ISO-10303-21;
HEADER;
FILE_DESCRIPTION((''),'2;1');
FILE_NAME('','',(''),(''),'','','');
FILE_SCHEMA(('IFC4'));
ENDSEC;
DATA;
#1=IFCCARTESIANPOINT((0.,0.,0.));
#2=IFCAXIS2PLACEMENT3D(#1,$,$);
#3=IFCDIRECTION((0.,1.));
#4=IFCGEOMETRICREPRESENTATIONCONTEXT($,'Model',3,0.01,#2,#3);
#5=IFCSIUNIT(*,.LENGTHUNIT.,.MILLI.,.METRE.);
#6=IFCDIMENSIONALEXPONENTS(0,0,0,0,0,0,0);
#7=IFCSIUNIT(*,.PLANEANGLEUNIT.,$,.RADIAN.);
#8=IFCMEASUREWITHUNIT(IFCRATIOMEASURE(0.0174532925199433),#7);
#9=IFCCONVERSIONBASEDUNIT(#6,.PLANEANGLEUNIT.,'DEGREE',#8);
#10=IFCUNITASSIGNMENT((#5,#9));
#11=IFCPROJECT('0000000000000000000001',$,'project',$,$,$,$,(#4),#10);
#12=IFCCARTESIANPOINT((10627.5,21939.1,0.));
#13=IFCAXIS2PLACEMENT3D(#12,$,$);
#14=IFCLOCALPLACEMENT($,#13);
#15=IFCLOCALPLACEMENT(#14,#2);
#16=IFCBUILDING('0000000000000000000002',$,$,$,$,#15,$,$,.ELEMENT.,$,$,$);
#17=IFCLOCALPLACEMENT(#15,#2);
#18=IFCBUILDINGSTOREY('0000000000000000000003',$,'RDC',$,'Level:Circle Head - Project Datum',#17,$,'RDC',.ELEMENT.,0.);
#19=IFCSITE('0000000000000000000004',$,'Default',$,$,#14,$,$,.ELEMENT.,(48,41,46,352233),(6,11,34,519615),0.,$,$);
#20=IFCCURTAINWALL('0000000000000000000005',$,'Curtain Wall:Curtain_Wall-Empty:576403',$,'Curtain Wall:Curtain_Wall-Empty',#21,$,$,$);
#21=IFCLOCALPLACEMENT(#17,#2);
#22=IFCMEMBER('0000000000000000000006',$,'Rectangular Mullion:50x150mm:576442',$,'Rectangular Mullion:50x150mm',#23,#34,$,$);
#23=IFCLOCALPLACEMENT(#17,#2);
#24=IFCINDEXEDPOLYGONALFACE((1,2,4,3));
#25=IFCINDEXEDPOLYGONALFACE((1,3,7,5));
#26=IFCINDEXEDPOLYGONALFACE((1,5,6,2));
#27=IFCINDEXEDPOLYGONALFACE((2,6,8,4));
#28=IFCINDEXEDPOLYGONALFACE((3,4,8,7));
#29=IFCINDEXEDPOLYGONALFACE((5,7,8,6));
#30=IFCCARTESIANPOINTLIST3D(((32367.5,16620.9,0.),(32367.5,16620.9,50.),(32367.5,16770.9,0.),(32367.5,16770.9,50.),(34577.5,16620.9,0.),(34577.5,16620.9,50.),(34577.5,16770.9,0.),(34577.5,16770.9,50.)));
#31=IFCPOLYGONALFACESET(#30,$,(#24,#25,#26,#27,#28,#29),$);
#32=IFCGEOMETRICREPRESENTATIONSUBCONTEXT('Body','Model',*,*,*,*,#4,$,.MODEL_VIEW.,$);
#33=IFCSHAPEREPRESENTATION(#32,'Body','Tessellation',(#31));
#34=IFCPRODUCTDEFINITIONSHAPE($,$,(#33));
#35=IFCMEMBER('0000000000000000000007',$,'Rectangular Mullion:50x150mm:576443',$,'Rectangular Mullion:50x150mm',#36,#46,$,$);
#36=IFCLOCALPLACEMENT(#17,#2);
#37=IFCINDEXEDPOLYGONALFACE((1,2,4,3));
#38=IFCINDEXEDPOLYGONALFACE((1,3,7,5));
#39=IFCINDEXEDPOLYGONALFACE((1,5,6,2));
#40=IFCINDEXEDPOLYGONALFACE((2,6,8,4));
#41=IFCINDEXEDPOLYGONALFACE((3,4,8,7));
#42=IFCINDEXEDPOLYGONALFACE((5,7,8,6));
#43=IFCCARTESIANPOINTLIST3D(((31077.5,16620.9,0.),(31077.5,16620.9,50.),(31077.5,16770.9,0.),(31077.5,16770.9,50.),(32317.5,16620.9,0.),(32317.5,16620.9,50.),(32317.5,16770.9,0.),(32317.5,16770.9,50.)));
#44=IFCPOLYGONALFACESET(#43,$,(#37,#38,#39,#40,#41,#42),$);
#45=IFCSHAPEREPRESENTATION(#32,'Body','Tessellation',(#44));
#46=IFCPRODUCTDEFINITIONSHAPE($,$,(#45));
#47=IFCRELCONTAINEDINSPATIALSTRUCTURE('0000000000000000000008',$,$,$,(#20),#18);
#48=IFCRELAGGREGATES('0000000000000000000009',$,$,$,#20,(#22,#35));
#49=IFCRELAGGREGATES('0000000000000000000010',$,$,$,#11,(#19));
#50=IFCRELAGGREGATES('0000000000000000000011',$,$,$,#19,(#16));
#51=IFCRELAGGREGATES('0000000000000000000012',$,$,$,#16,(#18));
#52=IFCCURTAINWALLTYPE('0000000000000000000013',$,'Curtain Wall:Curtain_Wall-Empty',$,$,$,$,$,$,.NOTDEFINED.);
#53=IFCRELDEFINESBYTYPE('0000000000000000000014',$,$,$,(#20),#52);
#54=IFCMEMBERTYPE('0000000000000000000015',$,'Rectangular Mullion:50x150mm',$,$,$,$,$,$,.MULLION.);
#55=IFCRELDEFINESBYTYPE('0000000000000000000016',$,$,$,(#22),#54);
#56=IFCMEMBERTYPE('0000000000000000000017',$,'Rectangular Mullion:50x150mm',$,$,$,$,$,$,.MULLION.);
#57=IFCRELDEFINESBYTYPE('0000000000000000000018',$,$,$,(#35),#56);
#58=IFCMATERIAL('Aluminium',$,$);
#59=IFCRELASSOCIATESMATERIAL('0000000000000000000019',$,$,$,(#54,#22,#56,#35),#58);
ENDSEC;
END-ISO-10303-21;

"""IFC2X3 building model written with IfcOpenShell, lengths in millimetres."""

from ifc_helpers import new_model, entity, si_unit, converted_unit, direction, frame, origin, origin_2d_with_axis, place, context, subcontext, project, spatial, rectangle, extrude, source, transform, mapped, material, type_object, type_shapes, element, aggregate, save


model = new_model("IFC2X3")

# Units and contexts
model_context = context("Model", 3, precision=0.01, world=origin(), true_north=direction((0.0, 1.0)))
body_context = subcontext(model_context, "Body", "Model", "MODEL_VIEW")
ifc_project = project(units=[si_unit("LENGTHUNIT", "METRE", prefix="MILLI"), converted_unit("PLANEANGLEUNIT", "DEGREE", entity("IfcRatioMeasure", 0.0174532925199433), si_unit("PLANEANGLEUNIT", "RADIAN"), dimensions=[0, 0, 0, 0, 0, 0, 0])], contexts=[model_context])

# Site, building, storey
site_placement = place(None, frame((10627.5, 21939.1, 0.0)))
site = spatial("IfcSite", under=ifc_project, at=site_placement, Name="Default", CompositionType="ELEMENT", RefLatitude=(48, 41, 46, 352233), RefLongitude=(6, 11, 34, 519615), RefElevation=0.0)
building_placement = place(site_placement, origin())
building = spatial("IfcBuilding", under=site, at=building_placement, CompositionType="ELEMENT")
storey_placement = place(building_placement, origin())
storey = spatial("IfcBuildingStorey", under=building, at=storey_placement, Name="RDC", ObjectType="Level:Circle Head - Project Datum", LongName="RDC", CompositionType="ELEMENT", Elevation=0.0)

# Curtain wall, members
curtain_wall_type = type_object("IfcCurtainWallType", Name="Curtain Wall:Curtain_Wall-Empty", PredefinedType="NOTDEFINED")
curtain_wall_placement = place(storey_placement, origin())
curtain_wall = element("IfcCurtainWall", 1, at=curtain_wall_placement, inside=storey, type_object=curtain_wall_type, Name="Curtain Wall:Curtain_Wall-Empty:576403", ObjectType="Curtain Wall:Curtain_Wall-Empty")
ifc_material_1 = material(Name="Aluminium")
member_type_1 = type_object("IfcMemberType", Name="Rectangular Mullion:50x150mm", PredefinedType="MULLION", material=ifc_material_1)
shared_shape_1 = source(origin(), body_context, "Body", "SweptSolid", [
    extrude(rectangle(XDim=150.0, YDim=50.0, at=origin_2d_with_axis()), frame((-25.0, 0.0, -2210.0), z_axis=(0.0, 0.0, 1.0), x_axis=(0.0, -1.0, 0.0)), (0.0, 0.0, 1.0), 2210.0),
])
type_shapes(member_type_1, [shared_shape_1])
member_1_placement = place(storey_placement, frame((34577.5, 16695.9, 0.0), z_axis=(1.0, 0.0, 0.0), x_axis=(0.0, 0.0, -1.0)))
member_1 = element("IfcMember", 2, at=member_1_placement, type_object=member_type_1, material=ifc_material_1, Name="Rectangular Mullion:50x150mm:576442", ObjectType="Rectangular Mullion:50x150mm", context=body_context, shape_type="MappedRepresentation", body=[
    mapped(shared_shape_1, transform((0.0, 0.0, 0.0), scale=1.0)),
])
member_type_2 = type_object("IfcMemberType", Name="Rectangular Mullion:50x150mm", PredefinedType="MULLION", material=ifc_material_1)
shared_shape_2 = source(origin(), body_context, "Body", "SweptSolid", [
    extrude(rectangle(XDim=150.0, YDim=50.0, at=origin_2d_with_axis()), frame((-25.0, 0.0, -1240.0), z_axis=(0.0, 0.0, 1.0), x_axis=(0.0, -1.0, 0.0)), (0.0, 0.0, 1.0), 1240.0),
])
type_shapes(member_type_2, [shared_shape_2])
member_2_placement = place(storey_placement, frame((32317.5, 16695.9, 0.0), z_axis=(1.0, 0.0, 0.0), x_axis=(0.0, 0.0, -1.0)))
member_2 = element("IfcMember", 3, at=member_2_placement, type_object=member_type_2, material=ifc_material_1, Name="Rectangular Mullion:50x150mm:576443", ObjectType="Rectangular Mullion:50x150mm", context=body_context, shape_type="MappedRepresentation", body=[
    mapped(shared_shape_2, transform((0.0, 0.0, 0.0), scale=1.0)),
])
aggregate(curtain_wall, [member_1, member_2])

save(model, "model.ifc")
